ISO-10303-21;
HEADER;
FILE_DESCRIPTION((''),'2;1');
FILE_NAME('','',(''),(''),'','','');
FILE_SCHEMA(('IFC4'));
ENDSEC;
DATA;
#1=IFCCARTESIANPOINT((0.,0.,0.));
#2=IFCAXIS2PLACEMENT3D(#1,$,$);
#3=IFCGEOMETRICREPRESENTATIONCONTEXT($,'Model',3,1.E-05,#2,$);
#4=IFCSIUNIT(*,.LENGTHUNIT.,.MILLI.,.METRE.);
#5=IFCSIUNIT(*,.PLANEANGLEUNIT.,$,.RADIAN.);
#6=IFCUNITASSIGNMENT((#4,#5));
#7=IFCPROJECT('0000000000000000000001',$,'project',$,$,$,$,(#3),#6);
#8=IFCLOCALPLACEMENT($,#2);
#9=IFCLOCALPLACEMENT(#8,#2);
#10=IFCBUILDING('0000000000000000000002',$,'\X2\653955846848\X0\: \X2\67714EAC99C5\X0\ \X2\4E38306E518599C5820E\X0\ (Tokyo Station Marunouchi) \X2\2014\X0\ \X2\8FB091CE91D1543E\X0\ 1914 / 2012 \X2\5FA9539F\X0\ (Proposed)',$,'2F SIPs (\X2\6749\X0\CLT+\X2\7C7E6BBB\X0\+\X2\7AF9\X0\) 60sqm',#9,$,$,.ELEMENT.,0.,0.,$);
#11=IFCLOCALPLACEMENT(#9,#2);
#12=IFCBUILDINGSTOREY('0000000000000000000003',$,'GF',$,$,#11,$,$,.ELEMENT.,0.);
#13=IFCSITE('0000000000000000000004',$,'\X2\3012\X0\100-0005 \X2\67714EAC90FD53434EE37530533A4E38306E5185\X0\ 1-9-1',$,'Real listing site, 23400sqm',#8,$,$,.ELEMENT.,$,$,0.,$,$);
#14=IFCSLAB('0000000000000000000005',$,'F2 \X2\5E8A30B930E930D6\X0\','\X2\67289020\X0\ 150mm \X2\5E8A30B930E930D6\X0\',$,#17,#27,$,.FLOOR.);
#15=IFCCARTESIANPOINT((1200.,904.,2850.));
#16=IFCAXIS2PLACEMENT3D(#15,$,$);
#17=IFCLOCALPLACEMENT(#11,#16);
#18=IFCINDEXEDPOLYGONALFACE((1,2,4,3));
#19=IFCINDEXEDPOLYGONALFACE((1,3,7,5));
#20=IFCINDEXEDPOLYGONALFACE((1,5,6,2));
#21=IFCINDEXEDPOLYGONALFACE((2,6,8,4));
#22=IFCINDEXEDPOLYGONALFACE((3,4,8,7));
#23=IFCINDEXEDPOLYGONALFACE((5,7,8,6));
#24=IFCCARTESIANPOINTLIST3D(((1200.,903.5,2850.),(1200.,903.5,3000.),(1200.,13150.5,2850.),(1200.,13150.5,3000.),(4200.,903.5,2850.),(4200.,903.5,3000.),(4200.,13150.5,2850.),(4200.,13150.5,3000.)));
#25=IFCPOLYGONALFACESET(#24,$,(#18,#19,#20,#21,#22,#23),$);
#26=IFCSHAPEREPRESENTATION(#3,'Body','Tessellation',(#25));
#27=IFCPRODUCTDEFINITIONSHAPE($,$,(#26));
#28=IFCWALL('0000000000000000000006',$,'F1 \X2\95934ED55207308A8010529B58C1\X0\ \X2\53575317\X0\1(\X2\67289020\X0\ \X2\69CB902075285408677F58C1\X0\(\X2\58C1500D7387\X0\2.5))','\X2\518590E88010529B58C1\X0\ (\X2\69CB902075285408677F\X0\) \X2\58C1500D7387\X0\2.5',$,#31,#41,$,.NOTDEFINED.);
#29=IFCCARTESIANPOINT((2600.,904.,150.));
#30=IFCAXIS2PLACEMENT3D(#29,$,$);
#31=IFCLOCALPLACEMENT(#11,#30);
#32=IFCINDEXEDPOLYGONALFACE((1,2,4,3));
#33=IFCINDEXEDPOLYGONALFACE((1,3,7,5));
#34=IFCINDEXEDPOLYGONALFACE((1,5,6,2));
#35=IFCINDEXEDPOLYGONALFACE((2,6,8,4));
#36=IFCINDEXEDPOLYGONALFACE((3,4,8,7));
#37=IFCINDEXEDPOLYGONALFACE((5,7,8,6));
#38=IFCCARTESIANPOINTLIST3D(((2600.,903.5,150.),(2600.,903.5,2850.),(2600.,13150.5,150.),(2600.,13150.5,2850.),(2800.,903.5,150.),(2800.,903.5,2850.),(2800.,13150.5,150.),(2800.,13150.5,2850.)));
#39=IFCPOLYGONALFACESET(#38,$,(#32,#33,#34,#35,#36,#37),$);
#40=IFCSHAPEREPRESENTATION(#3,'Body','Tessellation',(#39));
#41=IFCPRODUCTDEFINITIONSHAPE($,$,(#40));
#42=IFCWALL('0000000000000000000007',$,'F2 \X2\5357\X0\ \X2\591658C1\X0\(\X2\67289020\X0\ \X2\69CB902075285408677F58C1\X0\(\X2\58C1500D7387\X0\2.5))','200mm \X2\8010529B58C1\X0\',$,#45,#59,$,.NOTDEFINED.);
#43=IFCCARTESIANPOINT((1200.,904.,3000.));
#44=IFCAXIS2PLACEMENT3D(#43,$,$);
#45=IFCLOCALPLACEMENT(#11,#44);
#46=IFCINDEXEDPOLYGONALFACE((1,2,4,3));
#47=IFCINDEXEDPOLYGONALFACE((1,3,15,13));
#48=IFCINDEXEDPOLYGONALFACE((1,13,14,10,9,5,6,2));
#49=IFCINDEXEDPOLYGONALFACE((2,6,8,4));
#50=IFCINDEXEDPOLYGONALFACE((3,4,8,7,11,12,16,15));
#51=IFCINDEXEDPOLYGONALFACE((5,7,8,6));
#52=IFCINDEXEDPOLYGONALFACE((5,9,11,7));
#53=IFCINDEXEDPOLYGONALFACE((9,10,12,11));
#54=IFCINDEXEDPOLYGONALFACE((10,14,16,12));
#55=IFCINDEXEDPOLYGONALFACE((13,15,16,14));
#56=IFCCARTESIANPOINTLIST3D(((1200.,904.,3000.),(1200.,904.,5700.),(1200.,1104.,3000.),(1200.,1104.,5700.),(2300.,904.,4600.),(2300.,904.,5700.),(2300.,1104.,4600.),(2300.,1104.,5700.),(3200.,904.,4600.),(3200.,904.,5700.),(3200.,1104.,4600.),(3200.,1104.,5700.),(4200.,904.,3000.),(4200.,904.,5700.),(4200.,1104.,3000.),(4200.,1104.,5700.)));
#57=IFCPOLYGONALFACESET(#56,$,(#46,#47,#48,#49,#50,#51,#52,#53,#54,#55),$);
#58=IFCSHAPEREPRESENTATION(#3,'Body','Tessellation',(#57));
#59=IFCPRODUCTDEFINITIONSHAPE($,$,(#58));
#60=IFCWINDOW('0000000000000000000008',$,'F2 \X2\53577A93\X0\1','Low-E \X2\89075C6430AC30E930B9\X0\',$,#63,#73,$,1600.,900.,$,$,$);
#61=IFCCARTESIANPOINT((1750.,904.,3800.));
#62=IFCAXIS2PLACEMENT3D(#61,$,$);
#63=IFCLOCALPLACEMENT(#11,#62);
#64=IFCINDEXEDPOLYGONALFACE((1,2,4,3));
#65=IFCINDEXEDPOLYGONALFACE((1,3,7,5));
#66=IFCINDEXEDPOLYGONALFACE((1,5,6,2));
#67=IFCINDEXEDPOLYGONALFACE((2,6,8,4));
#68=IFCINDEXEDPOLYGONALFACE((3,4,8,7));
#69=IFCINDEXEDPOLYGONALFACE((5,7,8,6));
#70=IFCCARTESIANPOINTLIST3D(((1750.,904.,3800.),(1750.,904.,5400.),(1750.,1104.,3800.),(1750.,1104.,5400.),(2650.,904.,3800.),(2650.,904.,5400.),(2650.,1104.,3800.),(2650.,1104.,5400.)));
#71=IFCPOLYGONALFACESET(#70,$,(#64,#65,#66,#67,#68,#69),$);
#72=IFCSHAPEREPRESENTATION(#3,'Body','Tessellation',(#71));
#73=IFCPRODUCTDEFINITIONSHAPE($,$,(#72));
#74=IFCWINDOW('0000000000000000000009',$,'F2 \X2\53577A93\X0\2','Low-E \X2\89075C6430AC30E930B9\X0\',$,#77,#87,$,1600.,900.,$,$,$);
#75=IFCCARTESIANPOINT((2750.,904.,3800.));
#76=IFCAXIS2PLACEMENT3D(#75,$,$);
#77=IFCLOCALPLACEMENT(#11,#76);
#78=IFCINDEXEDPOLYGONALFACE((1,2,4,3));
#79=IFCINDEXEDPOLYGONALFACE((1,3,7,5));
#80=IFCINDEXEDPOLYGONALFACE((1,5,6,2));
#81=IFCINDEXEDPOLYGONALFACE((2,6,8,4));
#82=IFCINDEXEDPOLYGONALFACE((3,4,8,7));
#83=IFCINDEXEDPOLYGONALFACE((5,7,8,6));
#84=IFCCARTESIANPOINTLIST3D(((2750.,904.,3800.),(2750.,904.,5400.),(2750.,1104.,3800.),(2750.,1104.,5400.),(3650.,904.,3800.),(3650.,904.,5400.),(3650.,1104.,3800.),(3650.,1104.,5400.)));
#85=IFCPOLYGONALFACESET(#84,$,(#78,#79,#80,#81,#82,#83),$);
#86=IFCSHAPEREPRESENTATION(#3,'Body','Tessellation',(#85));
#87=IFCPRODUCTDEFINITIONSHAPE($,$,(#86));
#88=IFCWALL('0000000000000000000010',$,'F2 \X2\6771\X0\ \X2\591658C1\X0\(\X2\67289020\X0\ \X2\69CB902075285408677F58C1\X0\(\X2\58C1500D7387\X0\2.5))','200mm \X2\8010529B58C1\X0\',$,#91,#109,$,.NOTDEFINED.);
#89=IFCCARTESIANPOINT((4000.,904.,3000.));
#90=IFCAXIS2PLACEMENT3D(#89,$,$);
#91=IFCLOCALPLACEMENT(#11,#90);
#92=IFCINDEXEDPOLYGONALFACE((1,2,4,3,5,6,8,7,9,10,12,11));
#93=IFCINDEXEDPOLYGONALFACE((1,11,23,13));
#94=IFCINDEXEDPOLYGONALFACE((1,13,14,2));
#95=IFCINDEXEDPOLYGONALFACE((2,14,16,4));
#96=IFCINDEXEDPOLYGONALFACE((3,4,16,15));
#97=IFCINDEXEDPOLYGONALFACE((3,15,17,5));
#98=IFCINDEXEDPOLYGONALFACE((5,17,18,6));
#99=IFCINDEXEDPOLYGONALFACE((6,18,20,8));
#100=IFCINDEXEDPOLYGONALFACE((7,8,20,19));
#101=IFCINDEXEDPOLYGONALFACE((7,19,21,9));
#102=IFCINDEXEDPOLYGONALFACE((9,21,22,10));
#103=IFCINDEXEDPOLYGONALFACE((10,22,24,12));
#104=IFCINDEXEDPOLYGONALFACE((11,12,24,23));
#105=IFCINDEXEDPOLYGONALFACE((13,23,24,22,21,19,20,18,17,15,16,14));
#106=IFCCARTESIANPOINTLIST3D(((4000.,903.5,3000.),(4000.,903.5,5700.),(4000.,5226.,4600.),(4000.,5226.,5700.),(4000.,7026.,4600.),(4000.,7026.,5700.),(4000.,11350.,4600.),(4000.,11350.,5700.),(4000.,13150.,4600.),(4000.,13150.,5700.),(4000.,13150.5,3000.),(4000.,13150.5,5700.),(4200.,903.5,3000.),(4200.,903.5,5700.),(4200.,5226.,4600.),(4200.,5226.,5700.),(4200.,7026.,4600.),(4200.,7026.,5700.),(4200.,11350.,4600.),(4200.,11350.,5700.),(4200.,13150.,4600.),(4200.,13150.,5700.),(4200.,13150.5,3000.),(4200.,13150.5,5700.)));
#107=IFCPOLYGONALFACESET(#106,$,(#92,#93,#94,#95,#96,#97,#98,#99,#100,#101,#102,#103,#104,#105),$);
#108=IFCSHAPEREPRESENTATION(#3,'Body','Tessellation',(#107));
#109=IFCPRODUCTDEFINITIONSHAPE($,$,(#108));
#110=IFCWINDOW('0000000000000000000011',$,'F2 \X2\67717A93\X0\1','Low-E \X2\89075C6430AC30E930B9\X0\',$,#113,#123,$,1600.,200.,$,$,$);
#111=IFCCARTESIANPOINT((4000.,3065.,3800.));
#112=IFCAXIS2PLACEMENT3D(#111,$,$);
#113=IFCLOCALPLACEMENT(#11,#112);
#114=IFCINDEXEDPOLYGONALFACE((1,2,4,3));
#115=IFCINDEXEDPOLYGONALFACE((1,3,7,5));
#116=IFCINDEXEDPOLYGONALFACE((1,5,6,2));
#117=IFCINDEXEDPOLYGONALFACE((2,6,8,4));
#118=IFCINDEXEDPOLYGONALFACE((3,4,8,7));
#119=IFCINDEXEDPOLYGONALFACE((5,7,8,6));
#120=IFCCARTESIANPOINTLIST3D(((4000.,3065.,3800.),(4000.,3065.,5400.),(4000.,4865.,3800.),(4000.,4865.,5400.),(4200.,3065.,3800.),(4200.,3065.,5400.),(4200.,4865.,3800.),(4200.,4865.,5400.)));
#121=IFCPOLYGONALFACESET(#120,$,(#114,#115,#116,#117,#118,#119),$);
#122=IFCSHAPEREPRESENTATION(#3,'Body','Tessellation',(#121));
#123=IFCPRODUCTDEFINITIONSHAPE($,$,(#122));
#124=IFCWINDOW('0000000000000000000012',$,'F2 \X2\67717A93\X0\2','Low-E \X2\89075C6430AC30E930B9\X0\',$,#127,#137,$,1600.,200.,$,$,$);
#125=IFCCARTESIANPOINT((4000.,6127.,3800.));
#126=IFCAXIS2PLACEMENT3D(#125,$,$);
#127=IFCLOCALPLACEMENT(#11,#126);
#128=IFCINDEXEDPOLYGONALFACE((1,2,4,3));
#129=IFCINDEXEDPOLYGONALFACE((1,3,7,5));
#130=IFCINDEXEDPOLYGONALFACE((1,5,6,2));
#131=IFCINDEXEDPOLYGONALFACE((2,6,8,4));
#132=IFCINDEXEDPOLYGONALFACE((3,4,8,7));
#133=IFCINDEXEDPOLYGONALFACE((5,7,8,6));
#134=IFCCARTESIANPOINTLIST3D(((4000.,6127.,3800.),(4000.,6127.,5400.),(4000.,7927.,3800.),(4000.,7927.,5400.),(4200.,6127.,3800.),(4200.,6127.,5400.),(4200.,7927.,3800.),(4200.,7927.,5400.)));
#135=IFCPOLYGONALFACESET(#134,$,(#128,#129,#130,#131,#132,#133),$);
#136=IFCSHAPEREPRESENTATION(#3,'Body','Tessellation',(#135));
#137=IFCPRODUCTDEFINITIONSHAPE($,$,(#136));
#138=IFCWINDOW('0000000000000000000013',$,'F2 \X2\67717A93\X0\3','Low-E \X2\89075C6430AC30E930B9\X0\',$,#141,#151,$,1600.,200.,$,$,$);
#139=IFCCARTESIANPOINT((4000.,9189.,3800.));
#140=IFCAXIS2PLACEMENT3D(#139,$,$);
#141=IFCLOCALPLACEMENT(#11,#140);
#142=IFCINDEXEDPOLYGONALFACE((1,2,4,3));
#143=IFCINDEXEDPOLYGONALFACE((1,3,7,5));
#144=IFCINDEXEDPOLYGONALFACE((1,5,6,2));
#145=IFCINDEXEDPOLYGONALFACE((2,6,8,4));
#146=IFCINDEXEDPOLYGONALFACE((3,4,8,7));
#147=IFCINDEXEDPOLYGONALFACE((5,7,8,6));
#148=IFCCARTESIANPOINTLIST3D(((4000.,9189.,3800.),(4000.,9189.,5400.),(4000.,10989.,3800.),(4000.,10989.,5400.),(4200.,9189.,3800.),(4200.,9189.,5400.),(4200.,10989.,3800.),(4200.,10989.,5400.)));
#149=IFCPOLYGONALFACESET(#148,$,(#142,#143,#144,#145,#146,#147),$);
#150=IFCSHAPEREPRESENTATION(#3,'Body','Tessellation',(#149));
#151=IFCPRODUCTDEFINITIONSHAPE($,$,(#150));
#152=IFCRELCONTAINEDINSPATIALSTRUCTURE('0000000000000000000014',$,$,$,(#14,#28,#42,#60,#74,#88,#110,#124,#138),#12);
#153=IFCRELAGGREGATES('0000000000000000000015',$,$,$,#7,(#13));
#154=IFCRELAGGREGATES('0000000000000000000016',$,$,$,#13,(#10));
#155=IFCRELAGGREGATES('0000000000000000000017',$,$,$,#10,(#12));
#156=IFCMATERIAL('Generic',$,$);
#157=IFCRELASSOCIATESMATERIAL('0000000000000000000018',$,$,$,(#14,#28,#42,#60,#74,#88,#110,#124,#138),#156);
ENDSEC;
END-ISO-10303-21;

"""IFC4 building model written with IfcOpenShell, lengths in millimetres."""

from ifc_helpers import new_model, si_unit, frame, frame_2d, origin, place, context, project, spatial, rectangle, extrude, material, element, fill, save


model = new_model("IFC4")

# Units and contexts
model_context = context("Model", 3, precision=1e-05, world=origin())
ifc_project = project(units=[si_unit("LENGTHUNIT", "METRE", prefix="MILLI"), si_unit("PLANEANGLEUNIT", "RADIAN")], contexts=[model_context])

# Site, building, storey
site_placement = place(None, origin())
site = spatial("IfcSite", under=ifc_project, at=site_placement, Name="〒100-0005 東京都千代田区丸の内 1-9-1", ObjectType="Real listing site, 23400sqm", CompositionType="ELEMENT", RefElevation=0.0)
building_placement = place(site_placement, origin())
building = spatial("IfcBuilding", under=site, at=building_placement, Name="改善案: 東京駅 丸の内駅舎 (Tokyo Station Marunouchi) — 辰野金吾 1914 / 2012 復原 (Proposed)", ObjectType="2F SIPs (杉CLT+籾殻+竹) 60sqm", CompositionType="ELEMENT", ElevationOfRefHeight=0.0, ElevationOfTerrain=0.0)
storey_placement = place(building_placement, origin())
storey = spatial("IfcBuildingStorey", under=building, at=storey_placement, Name="GF", CompositionType="ELEMENT", Elevation=0.0)

# Slab
ifc_material = material(Name="Generic")
slab_placement = place(storey_placement, frame((1200.0, 904.0, 2850.0)))
element("IfcSlab", 1, at=slab_placement, inside=storey, material=ifc_material, Name="F2 床スラブ", Description="木造 150mm 床スラブ", PredefinedType="FLOOR", context=model_context, shape_type="SweptSolid", body=[
    extrude(rectangle(XDim=3000.0, YDim=12247.0, at=frame_2d((1500.0, 6123.0))), frame((1200.0, 904.0, 2850.0)), (0.0, 0.0, 1.0), 150.0),
])

# Wall
wall_1_placement = place(storey_placement, frame((2600.0, 904.0, 150.0)))
element("IfcWall", 2, at=wall_1_placement, inside=storey, material=ifc_material, Name="F1 間仕切り耐力壁 南北1(木造 構造用合板壁(壁倍率2.5))", Description="内部耐力壁 (構造用合板) 壁倍率2.5", PredefinedType="NOTDEFINED", context=model_context, shape_type="SweptSolid", body=[
    extrude(rectangle(XDim=200.0, YDim=12247.0, at=frame_2d((100.0, 6123.0))), frame((2600.0, 904.0, 150.0)), (0.0, 0.0, 1.0), 2700.0),
])

# Walls, openings, windows
wall_2_placement = place(storey_placement, frame((1200.0, 904.0, 3000.0)))
wall_2 = element("IfcWall", 3, at=wall_2_placement, inside=storey, material=ifc_material, Name="F2 南 外壁(木造 構造用合板壁(壁倍率2.5))", Description="200mm 耐力壁", PredefinedType="NOTDEFINED", context=model_context, shape_type="SweptSolid", body=[
    extrude(rectangle(XDim=3000.0, YDim=200.0, at=frame_2d((1500.0, 100.0))), frame((1200.0, 904.0, 3000.0)), (0.0, 0.0, 1.0), 2700.0),
])
opening_1_placement = place(storey_placement, frame((1750.0, 904.0, 3800.0)))
opening_1 = element("IfcOpeningElement", 4, at=opening_1_placement, cuts=wall_2, PredefinedType="NOTDEFINED", context=model_context, shape_type="SweptSolid", body=[
    extrude(rectangle(XDim=900.0, YDim=200.0, at=frame_2d((450.0, 100.0))), frame((1750.0, 904.0, 3800.0)), (0.0, 0.0, 1.0), 1600.0),
])
opening_2_placement = place(storey_placement, frame((2750.0, 904.0, 3800.0)))
opening_2 = element("IfcOpeningElement", 5, at=opening_2_placement, cuts=wall_2, PredefinedType="NOTDEFINED", context=model_context, shape_type="SweptSolid", body=[
    extrude(rectangle(XDim=900.0, YDim=200.0, at=frame_2d((450.0, 100.0))), frame((2750.0, 904.0, 3800.0)), (0.0, 0.0, 1.0), 1600.0),
])
window_1_placement = place(storey_placement, frame((1750.0, 904.0, 3800.0)))
window_1 = element("IfcWindow", 6, at=window_1_placement, inside=storey, material=ifc_material, Name="F2 南窓1", Description="Low-E 複層ガラス", OverallHeight=1600.0, OverallWidth=900.0, context=model_context, shape_type="SweptSolid", body=[
    extrude(rectangle(XDim=900.0, YDim=200.0, at=frame_2d((450.0, 100.0))), frame((1750.0, 904.0, 3800.0)), (0.0, 0.0, 1.0), 1600.0),
])
fill(opening_1, window_1)
window_2_placement = place(storey_placement, frame((2750.0, 904.0, 3800.0)))
window_2 = element("IfcWindow", 7, at=window_2_placement, inside=storey, material=ifc_material, Name="F2 南窓2", Description="Low-E 複層ガラス", OverallHeight=1600.0, OverallWidth=900.0, context=model_context, shape_type="SweptSolid", body=[
    extrude(rectangle(XDim=900.0, YDim=200.0, at=frame_2d((450.0, 100.0))), frame((2750.0, 904.0, 3800.0)), (0.0, 0.0, 1.0), 1600.0),
])
fill(opening_2, window_2)
wall_3_placement = place(storey_placement, frame((4000.0, 904.0, 3000.0)))
wall_3 = element("IfcWall", 8, at=wall_3_placement, inside=storey, material=ifc_material, Name="F2 東 外壁(木造 構造用合板壁(壁倍率2.5))", Description="200mm 耐力壁", PredefinedType="NOTDEFINED", context=model_context, shape_type="SweptSolid", body=[
    extrude(rectangle(XDim=200.0, YDim=12247.0, at=frame_2d((100.0, 6123.0))), frame((4000.0, 904.0, 3000.0)), (0.0, 0.0, 1.0), 2700.0),
])
opening_3_placement = place(storey_placement, frame((4000.0, 3065.0, 3800.0)))
opening_3 = element("IfcOpeningElement", 9, at=opening_3_placement, cuts=wall_3, PredefinedType="NOTDEFINED", context=model_context, shape_type="SweptSolid", body=[
    extrude(rectangle(XDim=200.0, YDim=1800.0, at=frame_2d((100.0, 900.0))), frame((4000.0, 3065.0, 3800.0)), (0.0, 0.0, 1.0), 1600.0),
])
opening_4_placement = place(storey_placement, frame((4000.0, 6127.0, 3800.0)))
opening_4 = element("IfcOpeningElement", 10, at=opening_4_placement, cuts=wall_3, PredefinedType="NOTDEFINED", context=model_context, shape_type="SweptSolid", body=[
    extrude(rectangle(XDim=200.0, YDim=1800.0, at=frame_2d((100.0, 900.0))), frame((4000.0, 6127.0, 3800.0)), (0.0, 0.0, 1.0), 1600.0),
])
opening_5_placement = place(storey_placement, frame((4000.0, 9189.0, 3800.0)))
opening_5 = element("IfcOpeningElement", 11, at=opening_5_placement, cuts=wall_3, PredefinedType="NOTDEFINED", context=model_context, shape_type="SweptSolid", body=[
    extrude(rectangle(XDim=200.0, YDim=1800.0, at=frame_2d((100.0, 900.0))), frame((4000.0, 9189.0, 3800.0)), (0.0, 0.0, 1.0), 1600.0),
])
window_3_placement = place(storey_placement, frame((4000.0, 3065.0, 3800.0)))
window_3 = element("IfcWindow", 12, at=window_3_placement, inside=storey, material=ifc_material, Name="F2 東窓1", Description="Low-E 複層ガラス", OverallHeight=1600.0, OverallWidth=200.0, context=model_context, shape_type="SweptSolid", body=[
    extrude(rectangle(XDim=200.0, YDim=1800.0, at=frame_2d((100.0, 900.0))), frame((4000.0, 3065.0, 3800.0)), (0.0, 0.0, 1.0), 1600.0),
])
fill(opening_3, window_3)
window_4_placement = place(storey_placement, frame((4000.0, 6127.0, 3800.0)))
window_4 = element("IfcWindow", 13, at=window_4_placement, inside=storey, material=ifc_material, Name="F2 東窓2", Description="Low-E 複層ガラス", OverallHeight=1600.0, OverallWidth=200.0, context=model_context, shape_type="SweptSolid", body=[
    extrude(rectangle(XDim=200.0, YDim=1800.0, at=frame_2d((100.0, 900.0))), frame((4000.0, 6127.0, 3800.0)), (0.0, 0.0, 1.0), 1600.0),
])
fill(opening_4, window_4)
window_5_placement = place(storey_placement, frame((4000.0, 9189.0, 3800.0)))
window_5 = element("IfcWindow", 14, at=window_5_placement, inside=storey, material=ifc_material, Name="F2 東窓3", Description="Low-E 複層ガラス", OverallHeight=1600.0, OverallWidth=200.0, context=model_context, shape_type="SweptSolid", body=[
    extrude(rectangle(XDim=200.0, YDim=1800.0, at=frame_2d((100.0, 900.0))), frame((4000.0, 9189.0, 3800.0)), (0.0, 0.0, 1.0), 1600.0),
])
fill(opening_5, window_5)

save(model, "model.ifc")
